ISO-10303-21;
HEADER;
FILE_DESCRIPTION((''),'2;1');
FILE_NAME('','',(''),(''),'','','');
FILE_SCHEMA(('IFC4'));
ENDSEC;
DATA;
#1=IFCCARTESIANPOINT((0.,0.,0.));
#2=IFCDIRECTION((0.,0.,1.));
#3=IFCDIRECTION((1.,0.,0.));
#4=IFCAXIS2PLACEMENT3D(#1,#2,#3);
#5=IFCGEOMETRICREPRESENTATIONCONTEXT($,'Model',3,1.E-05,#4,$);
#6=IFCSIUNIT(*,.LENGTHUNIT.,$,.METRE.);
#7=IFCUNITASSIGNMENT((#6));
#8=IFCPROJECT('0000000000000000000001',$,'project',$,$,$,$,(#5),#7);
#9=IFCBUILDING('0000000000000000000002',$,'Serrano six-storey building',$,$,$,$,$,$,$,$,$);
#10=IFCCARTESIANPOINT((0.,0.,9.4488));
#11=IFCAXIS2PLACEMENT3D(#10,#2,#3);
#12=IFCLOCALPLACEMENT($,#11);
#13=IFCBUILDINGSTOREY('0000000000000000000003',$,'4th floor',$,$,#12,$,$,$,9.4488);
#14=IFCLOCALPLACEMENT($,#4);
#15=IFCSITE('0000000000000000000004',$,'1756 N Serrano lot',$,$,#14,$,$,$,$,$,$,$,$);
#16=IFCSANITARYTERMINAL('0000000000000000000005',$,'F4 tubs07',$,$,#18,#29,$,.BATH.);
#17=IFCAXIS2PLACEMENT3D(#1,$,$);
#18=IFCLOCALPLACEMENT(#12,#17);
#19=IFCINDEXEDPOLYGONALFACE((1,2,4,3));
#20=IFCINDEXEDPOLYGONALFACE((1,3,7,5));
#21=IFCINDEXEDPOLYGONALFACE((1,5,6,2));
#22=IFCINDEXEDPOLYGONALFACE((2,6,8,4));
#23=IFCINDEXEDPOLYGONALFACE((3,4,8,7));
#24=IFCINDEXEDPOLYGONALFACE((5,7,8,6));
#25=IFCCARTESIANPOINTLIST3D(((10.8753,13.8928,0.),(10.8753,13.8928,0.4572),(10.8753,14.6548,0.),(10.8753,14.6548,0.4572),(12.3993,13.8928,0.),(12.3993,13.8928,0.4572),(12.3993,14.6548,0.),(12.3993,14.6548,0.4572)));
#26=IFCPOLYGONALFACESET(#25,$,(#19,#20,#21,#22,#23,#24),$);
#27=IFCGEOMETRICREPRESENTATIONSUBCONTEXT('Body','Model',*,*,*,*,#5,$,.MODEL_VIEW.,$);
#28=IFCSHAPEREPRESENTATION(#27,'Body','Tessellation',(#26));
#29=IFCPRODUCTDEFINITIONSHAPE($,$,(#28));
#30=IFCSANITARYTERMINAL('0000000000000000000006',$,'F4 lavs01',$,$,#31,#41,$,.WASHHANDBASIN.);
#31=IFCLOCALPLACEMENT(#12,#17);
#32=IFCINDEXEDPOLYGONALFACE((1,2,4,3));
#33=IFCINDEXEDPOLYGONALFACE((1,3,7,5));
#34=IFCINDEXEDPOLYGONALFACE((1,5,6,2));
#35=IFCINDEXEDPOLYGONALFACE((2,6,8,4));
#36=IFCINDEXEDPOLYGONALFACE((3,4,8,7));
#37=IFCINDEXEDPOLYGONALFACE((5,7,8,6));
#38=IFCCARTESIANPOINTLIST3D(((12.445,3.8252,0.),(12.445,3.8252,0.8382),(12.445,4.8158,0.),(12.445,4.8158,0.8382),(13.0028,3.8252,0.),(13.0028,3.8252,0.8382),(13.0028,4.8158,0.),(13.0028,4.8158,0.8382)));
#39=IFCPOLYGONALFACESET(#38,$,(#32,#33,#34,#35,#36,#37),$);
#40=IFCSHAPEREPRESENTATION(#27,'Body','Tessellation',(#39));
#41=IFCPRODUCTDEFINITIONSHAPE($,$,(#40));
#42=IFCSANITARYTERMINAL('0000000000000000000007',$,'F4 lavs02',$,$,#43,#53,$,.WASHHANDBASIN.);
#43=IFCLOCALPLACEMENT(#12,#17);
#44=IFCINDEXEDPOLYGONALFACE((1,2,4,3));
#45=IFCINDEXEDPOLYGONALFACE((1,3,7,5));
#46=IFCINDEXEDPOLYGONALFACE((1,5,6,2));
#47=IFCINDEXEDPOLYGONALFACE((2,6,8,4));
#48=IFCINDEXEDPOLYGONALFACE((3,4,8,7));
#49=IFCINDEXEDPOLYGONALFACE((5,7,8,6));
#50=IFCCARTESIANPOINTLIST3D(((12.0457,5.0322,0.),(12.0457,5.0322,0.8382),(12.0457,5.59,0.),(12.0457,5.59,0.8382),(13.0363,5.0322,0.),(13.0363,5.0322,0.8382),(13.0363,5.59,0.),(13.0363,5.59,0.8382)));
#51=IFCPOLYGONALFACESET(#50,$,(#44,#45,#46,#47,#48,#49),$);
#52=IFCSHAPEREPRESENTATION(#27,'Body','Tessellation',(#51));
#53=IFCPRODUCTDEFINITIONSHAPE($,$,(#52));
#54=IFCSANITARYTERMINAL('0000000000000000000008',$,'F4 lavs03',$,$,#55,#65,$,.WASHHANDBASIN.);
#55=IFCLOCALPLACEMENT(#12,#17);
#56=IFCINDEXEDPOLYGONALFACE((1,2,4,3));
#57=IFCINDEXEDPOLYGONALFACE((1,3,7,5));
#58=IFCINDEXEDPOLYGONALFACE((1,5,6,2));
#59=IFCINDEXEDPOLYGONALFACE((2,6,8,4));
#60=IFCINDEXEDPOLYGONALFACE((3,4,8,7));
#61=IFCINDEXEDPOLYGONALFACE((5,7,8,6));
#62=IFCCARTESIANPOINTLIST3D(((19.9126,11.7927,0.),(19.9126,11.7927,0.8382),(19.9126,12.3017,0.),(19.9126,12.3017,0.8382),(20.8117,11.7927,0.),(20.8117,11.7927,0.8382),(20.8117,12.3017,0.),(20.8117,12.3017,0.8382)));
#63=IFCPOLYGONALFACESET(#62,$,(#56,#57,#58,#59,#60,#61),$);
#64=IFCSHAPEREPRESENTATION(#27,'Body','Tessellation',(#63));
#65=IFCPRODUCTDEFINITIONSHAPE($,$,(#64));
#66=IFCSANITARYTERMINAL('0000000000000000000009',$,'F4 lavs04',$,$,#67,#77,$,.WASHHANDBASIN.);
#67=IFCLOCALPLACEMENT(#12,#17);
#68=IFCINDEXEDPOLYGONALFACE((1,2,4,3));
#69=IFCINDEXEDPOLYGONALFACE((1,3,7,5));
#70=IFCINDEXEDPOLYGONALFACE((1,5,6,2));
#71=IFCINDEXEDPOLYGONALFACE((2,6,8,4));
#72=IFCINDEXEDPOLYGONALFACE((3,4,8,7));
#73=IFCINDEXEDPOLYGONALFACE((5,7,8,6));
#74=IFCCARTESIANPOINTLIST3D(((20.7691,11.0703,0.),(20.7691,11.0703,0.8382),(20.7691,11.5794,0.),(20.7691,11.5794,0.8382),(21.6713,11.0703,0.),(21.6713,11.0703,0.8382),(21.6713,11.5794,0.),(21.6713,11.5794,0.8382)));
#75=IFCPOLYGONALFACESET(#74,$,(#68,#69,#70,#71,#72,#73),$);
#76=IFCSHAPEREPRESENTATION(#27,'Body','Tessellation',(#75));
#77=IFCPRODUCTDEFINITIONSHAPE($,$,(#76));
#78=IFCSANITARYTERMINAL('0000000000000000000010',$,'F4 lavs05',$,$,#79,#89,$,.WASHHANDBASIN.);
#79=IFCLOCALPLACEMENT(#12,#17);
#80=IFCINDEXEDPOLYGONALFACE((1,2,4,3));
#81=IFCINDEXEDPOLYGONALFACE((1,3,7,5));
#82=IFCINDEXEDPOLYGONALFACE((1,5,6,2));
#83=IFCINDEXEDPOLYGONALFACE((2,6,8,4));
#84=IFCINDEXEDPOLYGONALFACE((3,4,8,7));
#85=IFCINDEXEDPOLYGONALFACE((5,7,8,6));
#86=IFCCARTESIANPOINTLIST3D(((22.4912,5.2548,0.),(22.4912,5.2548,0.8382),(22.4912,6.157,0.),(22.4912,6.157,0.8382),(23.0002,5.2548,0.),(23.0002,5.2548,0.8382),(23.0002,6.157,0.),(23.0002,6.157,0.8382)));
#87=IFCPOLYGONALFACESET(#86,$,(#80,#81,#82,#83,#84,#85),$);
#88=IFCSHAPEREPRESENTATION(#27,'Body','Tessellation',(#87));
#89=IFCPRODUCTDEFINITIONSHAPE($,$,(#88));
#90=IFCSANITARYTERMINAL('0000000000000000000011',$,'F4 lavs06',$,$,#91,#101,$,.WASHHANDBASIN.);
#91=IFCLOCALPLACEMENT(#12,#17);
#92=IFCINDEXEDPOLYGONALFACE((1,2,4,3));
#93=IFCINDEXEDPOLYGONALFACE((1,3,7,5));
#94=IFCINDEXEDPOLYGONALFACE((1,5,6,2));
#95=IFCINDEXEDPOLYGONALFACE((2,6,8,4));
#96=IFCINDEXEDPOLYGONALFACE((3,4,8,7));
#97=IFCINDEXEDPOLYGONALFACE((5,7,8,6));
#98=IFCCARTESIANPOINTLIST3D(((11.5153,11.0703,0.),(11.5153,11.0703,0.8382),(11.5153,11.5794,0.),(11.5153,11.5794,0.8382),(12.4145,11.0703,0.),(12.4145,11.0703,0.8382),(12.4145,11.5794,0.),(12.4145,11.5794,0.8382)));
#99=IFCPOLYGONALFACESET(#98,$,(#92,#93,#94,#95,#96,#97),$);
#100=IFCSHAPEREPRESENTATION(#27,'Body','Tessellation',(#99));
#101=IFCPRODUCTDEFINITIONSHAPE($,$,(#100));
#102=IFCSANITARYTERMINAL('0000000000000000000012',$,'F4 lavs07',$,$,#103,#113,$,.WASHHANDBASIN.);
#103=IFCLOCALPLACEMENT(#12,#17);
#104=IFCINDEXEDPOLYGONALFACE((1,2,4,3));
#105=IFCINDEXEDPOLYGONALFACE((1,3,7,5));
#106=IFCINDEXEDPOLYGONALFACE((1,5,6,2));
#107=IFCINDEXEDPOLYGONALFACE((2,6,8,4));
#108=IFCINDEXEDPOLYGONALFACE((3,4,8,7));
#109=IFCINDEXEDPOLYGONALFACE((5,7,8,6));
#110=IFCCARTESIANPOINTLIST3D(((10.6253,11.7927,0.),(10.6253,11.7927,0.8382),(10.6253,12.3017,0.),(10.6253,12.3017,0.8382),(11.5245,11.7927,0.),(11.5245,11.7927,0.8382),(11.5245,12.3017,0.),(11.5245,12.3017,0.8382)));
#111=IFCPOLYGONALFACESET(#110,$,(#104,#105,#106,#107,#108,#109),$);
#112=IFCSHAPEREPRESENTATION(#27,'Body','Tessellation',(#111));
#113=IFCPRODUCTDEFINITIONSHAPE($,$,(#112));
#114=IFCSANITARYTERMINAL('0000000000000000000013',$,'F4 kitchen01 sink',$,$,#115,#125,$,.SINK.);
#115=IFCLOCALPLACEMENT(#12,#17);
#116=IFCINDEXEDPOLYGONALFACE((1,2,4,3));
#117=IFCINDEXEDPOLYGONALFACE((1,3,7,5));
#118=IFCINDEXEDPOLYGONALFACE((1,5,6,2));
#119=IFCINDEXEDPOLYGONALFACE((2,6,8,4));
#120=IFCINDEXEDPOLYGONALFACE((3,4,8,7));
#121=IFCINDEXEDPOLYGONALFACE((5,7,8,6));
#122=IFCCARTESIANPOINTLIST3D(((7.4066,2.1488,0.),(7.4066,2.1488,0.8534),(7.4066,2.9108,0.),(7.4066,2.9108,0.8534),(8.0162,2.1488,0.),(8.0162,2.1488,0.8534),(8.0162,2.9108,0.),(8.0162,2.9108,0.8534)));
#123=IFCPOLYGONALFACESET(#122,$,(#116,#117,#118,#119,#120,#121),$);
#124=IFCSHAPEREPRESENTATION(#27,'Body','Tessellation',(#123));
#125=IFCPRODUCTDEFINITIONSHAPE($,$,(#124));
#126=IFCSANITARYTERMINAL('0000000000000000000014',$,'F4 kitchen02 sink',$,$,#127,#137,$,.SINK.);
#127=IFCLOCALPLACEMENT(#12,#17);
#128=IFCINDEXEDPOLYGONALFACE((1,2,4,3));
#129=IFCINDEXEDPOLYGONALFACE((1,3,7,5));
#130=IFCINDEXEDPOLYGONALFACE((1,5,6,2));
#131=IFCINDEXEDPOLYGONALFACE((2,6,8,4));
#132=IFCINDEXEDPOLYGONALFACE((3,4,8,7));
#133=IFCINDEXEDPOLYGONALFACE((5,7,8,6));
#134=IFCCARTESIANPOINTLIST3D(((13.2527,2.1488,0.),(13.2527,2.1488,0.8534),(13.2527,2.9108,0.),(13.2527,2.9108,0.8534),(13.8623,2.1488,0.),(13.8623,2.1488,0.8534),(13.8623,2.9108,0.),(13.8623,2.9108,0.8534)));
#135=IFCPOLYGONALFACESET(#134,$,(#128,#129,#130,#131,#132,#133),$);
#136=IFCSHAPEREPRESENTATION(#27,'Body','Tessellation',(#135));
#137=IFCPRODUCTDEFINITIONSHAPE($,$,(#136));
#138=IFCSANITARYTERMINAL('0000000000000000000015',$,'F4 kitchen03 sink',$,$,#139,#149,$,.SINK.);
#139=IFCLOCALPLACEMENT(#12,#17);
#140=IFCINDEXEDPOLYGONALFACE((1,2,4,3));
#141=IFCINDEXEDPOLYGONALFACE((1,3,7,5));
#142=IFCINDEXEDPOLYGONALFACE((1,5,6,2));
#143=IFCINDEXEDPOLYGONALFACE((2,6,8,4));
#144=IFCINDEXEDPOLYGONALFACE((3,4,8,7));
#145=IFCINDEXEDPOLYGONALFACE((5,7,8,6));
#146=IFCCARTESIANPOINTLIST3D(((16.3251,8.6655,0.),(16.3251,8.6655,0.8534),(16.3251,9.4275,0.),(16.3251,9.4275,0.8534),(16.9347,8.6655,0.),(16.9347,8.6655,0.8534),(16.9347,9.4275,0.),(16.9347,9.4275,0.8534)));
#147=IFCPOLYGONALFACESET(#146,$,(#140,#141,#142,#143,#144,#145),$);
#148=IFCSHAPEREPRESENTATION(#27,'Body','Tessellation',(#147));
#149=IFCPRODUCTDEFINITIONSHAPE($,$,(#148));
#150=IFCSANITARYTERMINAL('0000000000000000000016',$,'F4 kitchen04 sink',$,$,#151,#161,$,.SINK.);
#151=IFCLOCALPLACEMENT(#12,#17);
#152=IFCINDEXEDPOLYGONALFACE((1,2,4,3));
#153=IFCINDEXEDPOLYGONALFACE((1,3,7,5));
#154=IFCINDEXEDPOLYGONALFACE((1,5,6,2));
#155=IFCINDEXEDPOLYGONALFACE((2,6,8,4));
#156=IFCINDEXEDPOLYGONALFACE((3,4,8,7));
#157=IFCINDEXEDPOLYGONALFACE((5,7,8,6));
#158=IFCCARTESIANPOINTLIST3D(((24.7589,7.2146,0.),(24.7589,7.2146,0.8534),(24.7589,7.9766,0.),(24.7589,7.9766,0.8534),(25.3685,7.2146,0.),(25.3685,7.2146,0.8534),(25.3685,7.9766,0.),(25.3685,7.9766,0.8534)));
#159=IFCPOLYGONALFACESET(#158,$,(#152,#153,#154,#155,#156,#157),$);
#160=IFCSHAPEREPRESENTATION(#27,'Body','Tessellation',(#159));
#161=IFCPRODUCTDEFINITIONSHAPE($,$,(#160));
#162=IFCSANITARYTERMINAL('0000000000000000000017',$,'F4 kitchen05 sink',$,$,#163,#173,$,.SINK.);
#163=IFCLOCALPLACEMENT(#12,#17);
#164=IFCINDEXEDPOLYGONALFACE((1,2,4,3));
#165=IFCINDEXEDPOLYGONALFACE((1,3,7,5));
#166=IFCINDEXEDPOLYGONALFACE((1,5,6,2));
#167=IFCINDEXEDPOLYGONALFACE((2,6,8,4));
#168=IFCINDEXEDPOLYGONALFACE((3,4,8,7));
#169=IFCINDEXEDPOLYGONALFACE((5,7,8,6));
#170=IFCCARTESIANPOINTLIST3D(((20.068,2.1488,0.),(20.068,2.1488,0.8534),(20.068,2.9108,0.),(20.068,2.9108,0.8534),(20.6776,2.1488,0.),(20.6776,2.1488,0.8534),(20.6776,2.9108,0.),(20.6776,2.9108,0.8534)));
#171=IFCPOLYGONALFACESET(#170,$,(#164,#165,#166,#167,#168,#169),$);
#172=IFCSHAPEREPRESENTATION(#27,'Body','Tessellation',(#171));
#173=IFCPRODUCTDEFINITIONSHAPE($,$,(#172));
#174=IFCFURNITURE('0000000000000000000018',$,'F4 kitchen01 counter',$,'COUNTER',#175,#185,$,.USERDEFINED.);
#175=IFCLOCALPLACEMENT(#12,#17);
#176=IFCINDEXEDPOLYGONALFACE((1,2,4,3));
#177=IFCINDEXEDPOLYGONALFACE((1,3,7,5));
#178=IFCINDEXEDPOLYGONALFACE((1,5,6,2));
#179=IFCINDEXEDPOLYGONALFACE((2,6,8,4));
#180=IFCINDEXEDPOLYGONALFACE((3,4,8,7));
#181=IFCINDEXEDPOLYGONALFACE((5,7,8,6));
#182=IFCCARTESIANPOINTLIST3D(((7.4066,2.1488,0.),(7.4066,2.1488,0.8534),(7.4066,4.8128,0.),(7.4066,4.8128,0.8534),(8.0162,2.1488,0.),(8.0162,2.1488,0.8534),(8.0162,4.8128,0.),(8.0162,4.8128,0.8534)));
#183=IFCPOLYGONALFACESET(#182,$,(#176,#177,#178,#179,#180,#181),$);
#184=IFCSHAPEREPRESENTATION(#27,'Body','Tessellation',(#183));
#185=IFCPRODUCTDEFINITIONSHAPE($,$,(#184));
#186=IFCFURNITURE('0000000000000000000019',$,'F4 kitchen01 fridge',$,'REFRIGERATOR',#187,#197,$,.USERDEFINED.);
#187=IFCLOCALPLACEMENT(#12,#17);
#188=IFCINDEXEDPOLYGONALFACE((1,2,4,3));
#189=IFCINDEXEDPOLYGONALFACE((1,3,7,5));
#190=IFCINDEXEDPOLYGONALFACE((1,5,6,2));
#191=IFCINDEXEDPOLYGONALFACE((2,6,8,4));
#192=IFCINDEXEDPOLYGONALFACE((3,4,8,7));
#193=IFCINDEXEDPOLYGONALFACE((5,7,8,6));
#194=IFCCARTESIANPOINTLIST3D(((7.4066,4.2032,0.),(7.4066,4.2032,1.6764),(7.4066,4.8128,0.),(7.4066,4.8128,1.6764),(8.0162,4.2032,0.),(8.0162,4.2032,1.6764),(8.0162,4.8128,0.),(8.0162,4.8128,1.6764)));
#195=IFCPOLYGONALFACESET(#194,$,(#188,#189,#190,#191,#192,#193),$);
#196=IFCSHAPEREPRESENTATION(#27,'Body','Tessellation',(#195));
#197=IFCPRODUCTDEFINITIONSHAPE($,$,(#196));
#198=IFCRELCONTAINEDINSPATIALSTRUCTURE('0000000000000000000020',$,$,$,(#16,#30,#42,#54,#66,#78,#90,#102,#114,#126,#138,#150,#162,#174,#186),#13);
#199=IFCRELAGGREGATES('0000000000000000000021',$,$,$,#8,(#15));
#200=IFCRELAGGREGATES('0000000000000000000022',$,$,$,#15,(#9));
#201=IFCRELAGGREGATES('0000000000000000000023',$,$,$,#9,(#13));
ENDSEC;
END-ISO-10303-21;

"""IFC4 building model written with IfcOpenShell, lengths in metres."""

from ifc_helpers import new_model, si_unit, frame, origin_with_axes, place, context, subcontext, project, spatial, polyline, outline, extrude, element, save


model = new_model("IFC4")

# Units and contexts
model_context = context("Model", 3, precision=1e-05, world=origin_with_axes())
body_context = subcontext(model_context, "Body", "Model", "MODEL_VIEW")
ifc_project = project(units=[si_unit("LENGTHUNIT", "METRE")], contexts=[model_context])

# Site, building, storey
site_placement = place(None, origin_with_axes())
site = spatial("IfcSite", under=ifc_project, at=site_placement, Name="1756 N Serrano lot")
building = spatial("IfcBuilding", under=site, Name="Serrano six-storey building")
storey_placement = place(None, frame((0.0, 0.0, 9.4488), z_axis=(0.0, 0.0, 1.0), x_axis=(1.0, 0.0, 0.0)))
storey = spatial("IfcBuildingStorey", under=building, at=storey_placement, Name="4th floor", Elevation=9.4488)

# Sanitary terminals
sanitary_terminal_1_placement = place(storey_placement, frame((0.0, 0.0, -9.4488), z_axis=(0.0, 0.0, 1.0), x_axis=(1.0, 0.0, 0.0)))
element("IfcSanitaryTerminal", 1, at=sanitary_terminal_1_placement, inside=storey, Name="F4 tubs07", PredefinedType="BATH", context=body_context, shape_type="SweptSolid", body=[
    extrude(outline(polyline([(12.3993, 13.8928), (12.3993, 14.6548), (10.8753, 14.6548), (10.8753, 13.8928), (12.3993, 13.8928)])), frame((0.0, 0.0, 9.4488)), (0.0, 0.0, 1.0), 0.4572),
])
sanitary_terminal_2_placement = place(storey_placement, frame((0.0, 0.0, -9.4488), z_axis=(0.0, 0.0, 1.0), x_axis=(1.0, 0.0, 0.0)))
element("IfcSanitaryTerminal", 2, at=sanitary_terminal_2_placement, inside=storey, Name="F4 lavs01", PredefinedType="WASHHANDBASIN", context=body_context, shape_type="SweptSolid", body=[
    extrude(outline(polyline([(13.0028, 3.8252), (13.0028, 4.8158), (12.445, 4.8158), (12.445, 3.8252), (13.0028, 3.8252)])), frame((0.0, 0.0, 9.4488)), (0.0, 0.0, 1.0), 0.8382),
])
sanitary_terminal_3_placement = place(storey_placement, frame((0.0, 0.0, -9.4488), z_axis=(0.0, 0.0, 1.0), x_axis=(1.0, 0.0, 0.0)))
element("IfcSanitaryTerminal", 3, at=sanitary_terminal_3_placement, inside=storey, Name="F4 lavs02", PredefinedType="WASHHANDBASIN", context=body_context, shape_type="SweptSolid", body=[
    extrude(outline(polyline([(13.0363, 5.0322), (13.0363, 5.59), (12.0457, 5.59), (12.0457, 5.0322), (13.0363, 5.0322)])), frame((0.0, 0.0, 9.4488)), (0.0, 0.0, 1.0), 0.8382),
])
sanitary_terminal_4_placement = place(storey_placement, frame((0.0, 0.0, -9.4488), z_axis=(0.0, 0.0, 1.0), x_axis=(1.0, 0.0, 0.0)))
element("IfcSanitaryTerminal", 4, at=sanitary_terminal_4_placement, inside=storey, Name="F4 lavs03", PredefinedType="WASHHANDBASIN", context=body_context, shape_type="SweptSolid", body=[
    extrude(outline(polyline([(20.8117, 11.7927), (20.8117, 12.3017), (19.9126, 12.3017), (19.9126, 11.7927), (20.8117, 11.7927)])), frame((0.0, 0.0, 9.4488)), (0.0, 0.0, 1.0), 0.8382),
])
sanitary_terminal_5_placement = place(storey_placement, frame((0.0, 0.0, -9.4488), z_axis=(0.0, 0.0, 1.0), x_axis=(1.0, 0.0, 0.0)))
element("IfcSanitaryTerminal", 5, at=sanitary_terminal_5_placement, inside=storey, Name="F4 lavs04", PredefinedType="WASHHANDBASIN", context=body_context, shape_type="SweptSolid", body=[
    extrude(outline(polyline([(21.6713, 11.0703), (21.6713, 11.5794), (20.7691, 11.5794), (20.7691, 11.0703), (21.6713, 11.0703)])), frame((0.0, 0.0, 9.4488)), (0.0, 0.0, 1.0), 0.8382),
])
sanitary_terminal_6_placement = place(storey_placement, frame((0.0, 0.0, -9.4488), z_axis=(0.0, 0.0, 1.0), x_axis=(1.0, 0.0, 0.0)))
element("IfcSanitaryTerminal", 6, at=sanitary_terminal_6_placement, inside=storey, Name="F4 lavs05", PredefinedType="WASHHANDBASIN", context=body_context, shape_type="SweptSolid", body=[
    extrude(outline(polyline([(23.0002, 5.2548), (23.0002, 6.157), (22.4912, 6.157), (22.4912, 5.2548), (23.0002, 5.2548)])), frame((0.0, 0.0, 9.4488)), (0.0, 0.0, 1.0), 0.8382),
])
sanitary_terminal_7_placement = place(storey_placement, frame((0.0, 0.0, -9.4488), z_axis=(0.0, 0.0, 1.0), x_axis=(1.0, 0.0, 0.0)))
element("IfcSanitaryTerminal", 7, at=sanitary_terminal_7_placement, inside=storey, Name="F4 lavs06", PredefinedType="WASHHANDBASIN", context=body_context, shape_type="SweptSolid", body=[
    extrude(outline(polyline([(12.4145, 11.0703), (12.4145, 11.5794), (11.5153, 11.5794), (11.5153, 11.0703), (12.4145, 11.0703)])), frame((0.0, 0.0, 9.4488)), (0.0, 0.0, 1.0), 0.8382),
])
sanitary_terminal_8_placement = place(storey_placement, frame((0.0, 0.0, -9.4488), z_axis=(0.0, 0.0, 1.0), x_axis=(1.0, 0.0, 0.0)))
element("IfcSanitaryTerminal", 8, at=sanitary_terminal_8_placement, inside=storey, Name="F4 lavs07", PredefinedType="WASHHANDBASIN", context=body_context, shape_type="SweptSolid", body=[
    extrude(outline(polyline([(11.5245, 11.7927), (11.5245, 12.3017), (10.6253, 12.3017), (10.6253, 11.7927), (11.5245, 11.7927)])), frame((0.0, 0.0, 9.4488)), (0.0, 0.0, 1.0), 0.8382),
])
sanitary_terminal_9_placement = place(storey_placement, frame((0.0, 0.0, -9.4488), z_axis=(0.0, 0.0, 1.0), x_axis=(1.0, 0.0, 0.0)))
element("IfcSanitaryTerminal", 9, at=sanitary_terminal_9_placement, inside=storey, Name="F4 kitchen01 sink", PredefinedType="SINK", context=body_context, shape_type="SweptSolid", body=[
    extrude(outline(polyline([(8.0162, 2.1488), (8.0162, 2.9108), (7.4066, 2.9108), (7.4066, 2.1488), (8.0162, 2.1488)])), frame((0.0, 0.0, 9.4488)), (0.0, 0.0, 1.0), 0.8534),
])
sanitary_terminal_10_placement = place(storey_placement, frame((0.0, 0.0, -9.4488), z_axis=(0.0, 0.0, 1.0), x_axis=(1.0, 0.0, 0.0)))
element("IfcSanitaryTerminal", 10, at=sanitary_terminal_10_placement, inside=storey, Name="F4 kitchen02 sink", PredefinedType="SINK", context=body_context, shape_type="SweptSolid", body=[
    extrude(outline(polyline([(13.8623, 2.1488), (13.8623, 2.9108), (13.2527, 2.9108), (13.2527, 2.1488), (13.8623, 2.1488)])), frame((0.0, 0.0, 9.4488)), (0.0, 0.0, 1.0), 0.8534),
])
sanitary_terminal_11_placement = place(storey_placement, frame((0.0, 0.0, -9.4488), z_axis=(0.0, 0.0, 1.0), x_axis=(1.0, 0.0, 0.0)))
element("IfcSanitaryTerminal", 11, at=sanitary_terminal_11_placement, inside=storey, Name="F4 kitchen03 sink", PredefinedType="SINK", context=body_context, shape_type="SweptSolid", body=[
    extrude(outline(polyline([(16.9347, 8.6655), (16.9347, 9.4275), (16.3251, 9.4275), (16.3251, 8.6655), (16.9347, 8.6655)])), frame((0.0, 0.0, 9.4488)), (0.0, 0.0, 1.0), 0.8534),
])
sanitary_terminal_12_placement = place(storey_placement, frame((0.0, 0.0, -9.4488), z_axis=(0.0, 0.0, 1.0), x_axis=(1.0, 0.0, 0.0)))
element("IfcSanitaryTerminal", 12, at=sanitary_terminal_12_placement, inside=storey, Name="F4 kitchen04 sink", PredefinedType="SINK", context=body_context, shape_type="SweptSolid", body=[
    extrude(outline(polyline([(25.3685, 7.2146), (25.3685, 7.9766), (24.7589, 7.9766), (24.7589, 7.2146), (25.3685, 7.2146)])), frame((0.0, 0.0, 9.4488)), (0.0, 0.0, 1.0), 0.8534),
])
sanitary_terminal_13_placement = place(storey_placement, frame((0.0, 0.0, -9.4488), z_axis=(0.0, 0.0, 1.0), x_axis=(1.0, 0.0, 0.0)))
element("IfcSanitaryTerminal", 13, at=sanitary_terminal_13_placement, inside=storey, Name="F4 kitchen05 sink", PredefinedType="SINK", context=body_context, shape_type="SweptSolid", body=[
    extrude(outline(polyline([(20.6776, 2.1488), (20.6776, 2.9108), (20.068, 2.9108), (20.068, 2.1488), (20.6776, 2.1488)])), frame((0.0, 0.0, 9.4488)), (0.0, 0.0, 1.0), 0.8534),
])

# Furniture
furniture_1_placement = place(storey_placement, frame((0.0, 0.0, -9.4488), z_axis=(0.0, 0.0, 1.0), x_axis=(1.0, 0.0, 0.0)))
element("IfcFurniture", 14, at=furniture_1_placement, inside=storey, Name="F4 kitchen01 counter", ObjectType="COUNTER", PredefinedType="USERDEFINED", context=body_context, shape_type="SweptSolid", body=[
    extrude(outline(polyline([(8.0162, 2.1488), (8.0162, 4.8128), (7.4066, 4.8128), (7.4066, 2.1488), (8.0162, 2.1488)])), frame((0.0, 0.0, 9.4488)), (0.0, 0.0, 1.0), 0.8534),
])
furniture_2_placement = place(storey_placement, frame((0.0, 0.0, -9.4488), z_axis=(0.0, 0.0, 1.0), x_axis=(1.0, 0.0, 0.0)))
element("IfcFurniture", 15, at=furniture_2_placement, inside=storey, Name="F4 kitchen01 fridge", ObjectType="REFRIGERATOR", PredefinedType="USERDEFINED", context=body_context, shape_type="SweptSolid", body=[
    extrude(outline(polyline([(8.0162, 4.2032), (8.0162, 4.8128), (7.4066, 4.8128), (7.4066, 4.2032), (8.0162, 4.2032)])), frame((0.0, 0.0, 9.4488)), (0.0, 0.0, 1.0), 1.6764),
])

save(model, "model.ifc")
